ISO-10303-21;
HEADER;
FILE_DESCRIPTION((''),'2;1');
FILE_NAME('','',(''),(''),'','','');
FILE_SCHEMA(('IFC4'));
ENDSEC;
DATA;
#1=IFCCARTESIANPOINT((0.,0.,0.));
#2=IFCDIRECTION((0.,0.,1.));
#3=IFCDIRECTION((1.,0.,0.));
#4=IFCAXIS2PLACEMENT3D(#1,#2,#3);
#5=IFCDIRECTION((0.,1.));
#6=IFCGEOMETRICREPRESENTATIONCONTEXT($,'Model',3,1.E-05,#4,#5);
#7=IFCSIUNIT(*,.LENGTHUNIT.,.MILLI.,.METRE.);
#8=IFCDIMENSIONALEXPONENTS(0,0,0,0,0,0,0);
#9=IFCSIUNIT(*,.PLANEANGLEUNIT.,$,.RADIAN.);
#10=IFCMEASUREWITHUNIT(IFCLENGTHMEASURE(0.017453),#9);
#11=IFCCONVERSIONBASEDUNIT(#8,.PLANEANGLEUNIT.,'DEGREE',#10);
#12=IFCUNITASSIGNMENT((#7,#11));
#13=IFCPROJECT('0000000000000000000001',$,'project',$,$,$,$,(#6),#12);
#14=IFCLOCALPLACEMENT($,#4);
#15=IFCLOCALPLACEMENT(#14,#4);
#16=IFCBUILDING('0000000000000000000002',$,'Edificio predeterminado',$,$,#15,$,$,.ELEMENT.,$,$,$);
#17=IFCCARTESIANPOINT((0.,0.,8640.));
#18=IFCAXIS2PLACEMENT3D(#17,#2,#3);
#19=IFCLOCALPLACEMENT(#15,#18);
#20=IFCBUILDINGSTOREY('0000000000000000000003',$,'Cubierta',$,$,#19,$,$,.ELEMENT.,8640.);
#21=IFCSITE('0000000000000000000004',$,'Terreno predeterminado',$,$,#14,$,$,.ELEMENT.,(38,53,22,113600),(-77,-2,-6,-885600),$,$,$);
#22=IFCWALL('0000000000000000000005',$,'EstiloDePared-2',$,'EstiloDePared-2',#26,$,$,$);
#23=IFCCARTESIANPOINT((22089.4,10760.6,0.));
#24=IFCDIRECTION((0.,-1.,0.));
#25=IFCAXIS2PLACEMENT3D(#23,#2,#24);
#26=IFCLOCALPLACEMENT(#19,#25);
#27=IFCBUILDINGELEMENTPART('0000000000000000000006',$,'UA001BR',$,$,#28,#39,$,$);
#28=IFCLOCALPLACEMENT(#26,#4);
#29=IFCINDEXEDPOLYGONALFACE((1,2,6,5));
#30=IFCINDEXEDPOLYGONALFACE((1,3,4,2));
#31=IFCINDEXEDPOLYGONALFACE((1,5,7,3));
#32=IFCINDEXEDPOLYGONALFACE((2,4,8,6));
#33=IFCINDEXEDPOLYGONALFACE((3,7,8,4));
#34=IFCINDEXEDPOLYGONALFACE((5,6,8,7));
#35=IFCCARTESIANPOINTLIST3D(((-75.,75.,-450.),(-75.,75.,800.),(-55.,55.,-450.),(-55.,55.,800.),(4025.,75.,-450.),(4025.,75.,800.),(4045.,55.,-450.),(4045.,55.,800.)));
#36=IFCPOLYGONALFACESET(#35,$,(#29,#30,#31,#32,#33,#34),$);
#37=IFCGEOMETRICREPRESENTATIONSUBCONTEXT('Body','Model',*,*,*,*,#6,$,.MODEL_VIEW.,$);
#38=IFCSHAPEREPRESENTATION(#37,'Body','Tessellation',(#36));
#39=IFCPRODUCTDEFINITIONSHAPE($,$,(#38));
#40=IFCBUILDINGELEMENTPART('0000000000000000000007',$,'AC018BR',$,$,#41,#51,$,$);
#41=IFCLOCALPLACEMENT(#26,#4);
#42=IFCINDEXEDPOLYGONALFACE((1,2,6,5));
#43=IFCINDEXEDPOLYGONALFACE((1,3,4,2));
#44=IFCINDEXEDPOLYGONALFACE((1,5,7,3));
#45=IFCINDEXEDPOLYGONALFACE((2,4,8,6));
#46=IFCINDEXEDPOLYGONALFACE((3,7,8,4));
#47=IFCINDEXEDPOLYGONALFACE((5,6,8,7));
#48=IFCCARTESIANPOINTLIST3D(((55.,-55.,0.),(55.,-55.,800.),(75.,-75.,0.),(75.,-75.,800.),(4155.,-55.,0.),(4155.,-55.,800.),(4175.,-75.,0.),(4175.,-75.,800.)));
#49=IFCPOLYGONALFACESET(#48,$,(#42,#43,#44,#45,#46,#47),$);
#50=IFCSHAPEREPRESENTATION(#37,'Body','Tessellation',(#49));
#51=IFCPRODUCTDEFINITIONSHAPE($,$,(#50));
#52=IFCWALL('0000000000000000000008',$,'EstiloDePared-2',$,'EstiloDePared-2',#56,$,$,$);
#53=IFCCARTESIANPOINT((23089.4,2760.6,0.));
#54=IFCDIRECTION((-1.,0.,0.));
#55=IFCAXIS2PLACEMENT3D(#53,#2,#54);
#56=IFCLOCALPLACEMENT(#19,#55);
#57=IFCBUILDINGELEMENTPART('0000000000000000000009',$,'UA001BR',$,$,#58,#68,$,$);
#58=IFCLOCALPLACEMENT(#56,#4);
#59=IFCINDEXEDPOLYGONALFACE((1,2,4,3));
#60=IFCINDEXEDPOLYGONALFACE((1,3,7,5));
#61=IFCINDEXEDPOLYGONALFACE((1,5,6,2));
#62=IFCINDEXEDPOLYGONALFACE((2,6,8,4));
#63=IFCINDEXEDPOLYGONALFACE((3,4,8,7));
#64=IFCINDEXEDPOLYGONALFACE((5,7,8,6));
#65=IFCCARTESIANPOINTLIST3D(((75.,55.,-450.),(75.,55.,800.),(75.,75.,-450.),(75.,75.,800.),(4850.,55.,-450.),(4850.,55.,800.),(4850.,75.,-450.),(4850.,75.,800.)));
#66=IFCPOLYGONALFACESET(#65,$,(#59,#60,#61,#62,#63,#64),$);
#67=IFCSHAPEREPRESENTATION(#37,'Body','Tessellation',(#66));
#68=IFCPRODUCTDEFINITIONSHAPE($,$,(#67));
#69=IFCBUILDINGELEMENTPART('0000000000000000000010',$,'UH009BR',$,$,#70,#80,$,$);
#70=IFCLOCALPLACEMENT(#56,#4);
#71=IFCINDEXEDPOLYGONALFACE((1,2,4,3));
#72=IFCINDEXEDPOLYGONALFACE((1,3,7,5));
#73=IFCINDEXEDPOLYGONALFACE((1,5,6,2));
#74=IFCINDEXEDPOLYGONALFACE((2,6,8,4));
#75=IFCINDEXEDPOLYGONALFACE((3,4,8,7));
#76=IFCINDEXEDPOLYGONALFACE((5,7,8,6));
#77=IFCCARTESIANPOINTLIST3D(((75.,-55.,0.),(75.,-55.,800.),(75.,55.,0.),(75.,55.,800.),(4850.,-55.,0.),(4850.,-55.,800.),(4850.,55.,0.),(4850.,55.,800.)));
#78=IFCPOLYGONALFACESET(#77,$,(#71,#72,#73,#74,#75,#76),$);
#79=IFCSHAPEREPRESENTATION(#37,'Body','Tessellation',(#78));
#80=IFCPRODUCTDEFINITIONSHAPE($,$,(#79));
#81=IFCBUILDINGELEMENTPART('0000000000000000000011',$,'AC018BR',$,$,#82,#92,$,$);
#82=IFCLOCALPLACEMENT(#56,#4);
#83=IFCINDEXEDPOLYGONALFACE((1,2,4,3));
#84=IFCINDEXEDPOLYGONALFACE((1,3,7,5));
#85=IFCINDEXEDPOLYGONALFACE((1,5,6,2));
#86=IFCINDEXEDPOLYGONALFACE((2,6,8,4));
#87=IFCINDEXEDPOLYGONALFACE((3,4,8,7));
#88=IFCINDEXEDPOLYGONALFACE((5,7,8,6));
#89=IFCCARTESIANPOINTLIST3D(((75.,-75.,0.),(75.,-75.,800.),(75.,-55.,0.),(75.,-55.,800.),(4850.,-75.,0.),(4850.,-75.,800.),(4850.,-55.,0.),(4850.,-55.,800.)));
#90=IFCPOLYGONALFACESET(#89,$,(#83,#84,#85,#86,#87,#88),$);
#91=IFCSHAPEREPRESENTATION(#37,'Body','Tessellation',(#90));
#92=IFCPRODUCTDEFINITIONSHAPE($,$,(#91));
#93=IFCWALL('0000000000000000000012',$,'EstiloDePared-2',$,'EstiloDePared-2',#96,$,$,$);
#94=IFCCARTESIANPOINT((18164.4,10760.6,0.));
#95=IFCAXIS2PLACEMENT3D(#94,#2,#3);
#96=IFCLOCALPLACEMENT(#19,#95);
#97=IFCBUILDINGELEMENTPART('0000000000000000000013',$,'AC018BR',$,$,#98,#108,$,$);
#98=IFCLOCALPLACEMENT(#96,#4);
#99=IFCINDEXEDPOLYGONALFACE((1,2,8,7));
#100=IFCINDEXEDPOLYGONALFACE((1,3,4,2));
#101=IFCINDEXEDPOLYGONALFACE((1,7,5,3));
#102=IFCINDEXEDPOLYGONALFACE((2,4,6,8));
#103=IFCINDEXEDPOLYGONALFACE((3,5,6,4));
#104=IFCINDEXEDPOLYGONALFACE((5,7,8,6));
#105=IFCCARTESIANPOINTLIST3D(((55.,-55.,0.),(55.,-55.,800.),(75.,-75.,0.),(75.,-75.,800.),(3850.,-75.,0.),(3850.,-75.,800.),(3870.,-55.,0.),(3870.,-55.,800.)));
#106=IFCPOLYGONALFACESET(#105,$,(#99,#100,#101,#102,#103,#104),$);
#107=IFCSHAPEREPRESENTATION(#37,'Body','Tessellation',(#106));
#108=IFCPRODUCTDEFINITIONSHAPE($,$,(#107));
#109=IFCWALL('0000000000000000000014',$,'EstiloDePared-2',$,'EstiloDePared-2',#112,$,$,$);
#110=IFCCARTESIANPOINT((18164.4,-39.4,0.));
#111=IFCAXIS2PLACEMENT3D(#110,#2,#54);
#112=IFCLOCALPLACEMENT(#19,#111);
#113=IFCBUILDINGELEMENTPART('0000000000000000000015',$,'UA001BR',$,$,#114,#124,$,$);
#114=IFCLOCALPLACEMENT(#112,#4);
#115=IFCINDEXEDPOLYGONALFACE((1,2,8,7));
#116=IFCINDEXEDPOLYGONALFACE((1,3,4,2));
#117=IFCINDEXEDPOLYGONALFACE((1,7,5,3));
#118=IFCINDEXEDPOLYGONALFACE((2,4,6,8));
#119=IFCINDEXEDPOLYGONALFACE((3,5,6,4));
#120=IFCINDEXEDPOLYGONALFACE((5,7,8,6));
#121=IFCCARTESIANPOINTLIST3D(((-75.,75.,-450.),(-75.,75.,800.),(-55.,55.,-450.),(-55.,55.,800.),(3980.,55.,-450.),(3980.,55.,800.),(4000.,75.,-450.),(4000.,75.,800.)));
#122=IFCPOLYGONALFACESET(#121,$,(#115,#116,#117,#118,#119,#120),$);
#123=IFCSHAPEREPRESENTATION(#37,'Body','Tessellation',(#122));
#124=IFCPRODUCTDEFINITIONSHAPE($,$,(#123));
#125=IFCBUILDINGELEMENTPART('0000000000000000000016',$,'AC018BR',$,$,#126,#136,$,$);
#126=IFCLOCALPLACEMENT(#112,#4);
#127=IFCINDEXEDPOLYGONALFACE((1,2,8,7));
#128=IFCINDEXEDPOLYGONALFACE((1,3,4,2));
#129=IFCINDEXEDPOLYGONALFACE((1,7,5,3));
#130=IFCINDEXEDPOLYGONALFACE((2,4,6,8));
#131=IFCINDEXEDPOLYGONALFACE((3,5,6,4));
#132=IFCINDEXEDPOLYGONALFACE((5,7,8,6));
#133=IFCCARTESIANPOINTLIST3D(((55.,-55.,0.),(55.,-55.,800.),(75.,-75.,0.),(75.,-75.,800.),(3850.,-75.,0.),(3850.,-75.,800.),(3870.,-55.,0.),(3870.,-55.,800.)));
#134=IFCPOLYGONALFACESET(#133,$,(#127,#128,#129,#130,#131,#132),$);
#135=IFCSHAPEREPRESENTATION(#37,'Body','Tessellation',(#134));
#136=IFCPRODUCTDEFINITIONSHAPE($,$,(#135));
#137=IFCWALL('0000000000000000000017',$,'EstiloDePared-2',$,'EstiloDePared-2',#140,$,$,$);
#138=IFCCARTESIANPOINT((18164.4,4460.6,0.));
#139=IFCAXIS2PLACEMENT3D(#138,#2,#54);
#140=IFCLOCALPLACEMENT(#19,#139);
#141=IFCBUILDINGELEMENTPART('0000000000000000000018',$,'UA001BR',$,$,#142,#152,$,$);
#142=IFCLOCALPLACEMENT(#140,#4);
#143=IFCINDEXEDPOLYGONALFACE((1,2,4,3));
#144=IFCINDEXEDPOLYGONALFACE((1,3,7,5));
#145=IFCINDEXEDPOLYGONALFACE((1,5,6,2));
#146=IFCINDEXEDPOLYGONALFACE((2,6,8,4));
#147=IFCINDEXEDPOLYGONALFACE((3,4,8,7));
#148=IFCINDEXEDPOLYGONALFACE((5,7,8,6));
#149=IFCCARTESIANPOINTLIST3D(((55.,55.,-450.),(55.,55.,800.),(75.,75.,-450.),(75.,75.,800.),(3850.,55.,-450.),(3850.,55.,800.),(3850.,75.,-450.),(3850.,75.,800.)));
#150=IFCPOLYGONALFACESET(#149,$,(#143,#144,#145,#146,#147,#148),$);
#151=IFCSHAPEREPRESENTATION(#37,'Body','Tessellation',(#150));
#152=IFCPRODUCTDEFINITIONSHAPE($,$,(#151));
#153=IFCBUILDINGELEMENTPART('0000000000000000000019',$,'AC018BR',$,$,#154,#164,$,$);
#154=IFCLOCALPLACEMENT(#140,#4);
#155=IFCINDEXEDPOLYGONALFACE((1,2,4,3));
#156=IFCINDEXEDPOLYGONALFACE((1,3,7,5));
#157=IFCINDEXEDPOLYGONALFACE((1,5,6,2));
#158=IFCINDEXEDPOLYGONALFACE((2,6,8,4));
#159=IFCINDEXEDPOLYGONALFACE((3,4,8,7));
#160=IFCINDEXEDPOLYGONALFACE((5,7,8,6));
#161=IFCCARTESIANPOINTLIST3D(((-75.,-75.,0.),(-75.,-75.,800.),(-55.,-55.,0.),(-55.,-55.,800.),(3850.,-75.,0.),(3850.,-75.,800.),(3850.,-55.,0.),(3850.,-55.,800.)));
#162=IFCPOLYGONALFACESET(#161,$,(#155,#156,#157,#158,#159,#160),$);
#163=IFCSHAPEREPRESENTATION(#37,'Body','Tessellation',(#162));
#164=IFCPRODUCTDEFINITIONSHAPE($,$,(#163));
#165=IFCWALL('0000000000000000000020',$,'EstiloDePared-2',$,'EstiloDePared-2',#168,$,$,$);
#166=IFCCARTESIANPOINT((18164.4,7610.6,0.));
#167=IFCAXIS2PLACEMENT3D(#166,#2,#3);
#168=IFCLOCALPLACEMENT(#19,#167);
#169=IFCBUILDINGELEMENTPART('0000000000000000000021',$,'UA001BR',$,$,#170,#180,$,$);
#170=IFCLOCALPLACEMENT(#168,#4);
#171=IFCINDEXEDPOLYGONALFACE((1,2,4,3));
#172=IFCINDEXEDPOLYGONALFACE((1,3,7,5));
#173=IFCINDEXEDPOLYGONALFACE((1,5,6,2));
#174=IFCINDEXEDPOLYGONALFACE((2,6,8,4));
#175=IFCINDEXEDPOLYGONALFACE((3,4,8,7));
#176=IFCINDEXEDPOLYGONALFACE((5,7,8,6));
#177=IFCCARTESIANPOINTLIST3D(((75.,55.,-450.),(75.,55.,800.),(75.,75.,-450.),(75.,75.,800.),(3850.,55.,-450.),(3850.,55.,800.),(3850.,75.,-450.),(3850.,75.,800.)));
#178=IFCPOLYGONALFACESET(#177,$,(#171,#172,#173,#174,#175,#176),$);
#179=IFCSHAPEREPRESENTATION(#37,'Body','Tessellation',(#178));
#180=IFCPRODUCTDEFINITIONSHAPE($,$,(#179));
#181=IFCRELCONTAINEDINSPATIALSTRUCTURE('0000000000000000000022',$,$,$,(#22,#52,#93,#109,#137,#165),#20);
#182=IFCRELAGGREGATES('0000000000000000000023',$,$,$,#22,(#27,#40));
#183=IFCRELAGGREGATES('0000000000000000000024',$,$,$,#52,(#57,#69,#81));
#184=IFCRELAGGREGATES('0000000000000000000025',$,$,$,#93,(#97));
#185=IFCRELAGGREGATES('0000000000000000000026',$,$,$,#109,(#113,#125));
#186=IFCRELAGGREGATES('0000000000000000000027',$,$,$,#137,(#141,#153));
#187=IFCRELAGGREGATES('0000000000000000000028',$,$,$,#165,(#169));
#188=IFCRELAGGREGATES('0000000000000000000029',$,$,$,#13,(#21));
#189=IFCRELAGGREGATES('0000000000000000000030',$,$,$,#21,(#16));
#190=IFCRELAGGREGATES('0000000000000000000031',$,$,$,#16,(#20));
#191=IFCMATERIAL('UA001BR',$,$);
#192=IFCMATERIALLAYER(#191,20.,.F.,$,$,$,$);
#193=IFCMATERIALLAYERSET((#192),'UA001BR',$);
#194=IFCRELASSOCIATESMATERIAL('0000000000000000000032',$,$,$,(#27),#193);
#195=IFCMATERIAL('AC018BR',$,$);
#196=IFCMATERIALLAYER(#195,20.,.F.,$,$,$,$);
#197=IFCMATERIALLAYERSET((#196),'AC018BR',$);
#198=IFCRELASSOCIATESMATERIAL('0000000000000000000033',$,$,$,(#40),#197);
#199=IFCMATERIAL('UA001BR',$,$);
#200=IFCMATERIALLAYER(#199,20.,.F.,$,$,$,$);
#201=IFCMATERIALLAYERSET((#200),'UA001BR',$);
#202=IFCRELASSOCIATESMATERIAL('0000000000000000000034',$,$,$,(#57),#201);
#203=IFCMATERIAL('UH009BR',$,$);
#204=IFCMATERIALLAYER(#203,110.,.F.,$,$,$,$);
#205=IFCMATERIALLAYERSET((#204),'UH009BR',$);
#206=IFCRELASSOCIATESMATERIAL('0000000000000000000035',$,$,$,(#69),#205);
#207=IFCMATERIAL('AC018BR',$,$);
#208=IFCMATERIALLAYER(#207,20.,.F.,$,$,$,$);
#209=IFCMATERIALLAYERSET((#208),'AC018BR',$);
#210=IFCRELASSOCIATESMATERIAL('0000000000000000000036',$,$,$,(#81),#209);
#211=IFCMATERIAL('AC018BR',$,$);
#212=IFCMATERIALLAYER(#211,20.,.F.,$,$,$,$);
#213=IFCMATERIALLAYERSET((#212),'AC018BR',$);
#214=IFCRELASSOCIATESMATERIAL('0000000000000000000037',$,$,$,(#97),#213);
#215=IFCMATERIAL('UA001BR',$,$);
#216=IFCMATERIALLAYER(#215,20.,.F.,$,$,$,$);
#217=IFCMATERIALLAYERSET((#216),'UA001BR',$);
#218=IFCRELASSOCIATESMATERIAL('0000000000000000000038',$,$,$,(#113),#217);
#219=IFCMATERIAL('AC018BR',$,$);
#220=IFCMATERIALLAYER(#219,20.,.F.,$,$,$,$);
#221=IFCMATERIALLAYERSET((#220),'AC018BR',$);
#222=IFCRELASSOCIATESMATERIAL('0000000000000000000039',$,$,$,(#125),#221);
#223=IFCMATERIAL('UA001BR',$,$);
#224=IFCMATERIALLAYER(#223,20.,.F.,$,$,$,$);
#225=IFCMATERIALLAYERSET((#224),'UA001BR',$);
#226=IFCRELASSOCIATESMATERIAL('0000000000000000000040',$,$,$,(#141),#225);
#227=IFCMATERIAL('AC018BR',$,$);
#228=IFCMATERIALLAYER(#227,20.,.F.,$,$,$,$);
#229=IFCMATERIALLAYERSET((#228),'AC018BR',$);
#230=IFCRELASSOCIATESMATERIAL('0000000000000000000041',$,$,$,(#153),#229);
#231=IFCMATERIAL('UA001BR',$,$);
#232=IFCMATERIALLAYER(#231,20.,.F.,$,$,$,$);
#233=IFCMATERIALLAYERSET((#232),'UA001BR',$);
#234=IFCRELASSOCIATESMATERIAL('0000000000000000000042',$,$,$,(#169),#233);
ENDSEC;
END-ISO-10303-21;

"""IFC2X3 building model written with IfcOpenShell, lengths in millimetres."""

from ifc_helpers import new_model, entity, si_unit, converted_unit, direction, frame, origin_with_axes, place, context, subcontext, project, spatial, polyline, outline, extrude, material, layer, layer_set, layer_usage, element, aggregate, save


model = new_model("IFC2X3")

# Units and contexts
model_context = context("Model", 3, precision=1e-05, world=origin_with_axes(), true_north=direction((0.0, 1.0)))
body_context = subcontext(model_context, "Body", "Model", "MODEL_VIEW")
ifc_project = project(units=[si_unit("LENGTHUNIT", "METRE", prefix="MILLI"), converted_unit("PLANEANGLEUNIT", "DEGREE", entity("IfcLengthMeasure", 0.017453), si_unit("PLANEANGLEUNIT", "RADIAN"), dimensions=[0, 0, 0, 0, 0, 0, 0])], contexts=[model_context])

# Site, building, storey
site_placement = place(None, origin_with_axes())
site = spatial("IfcSite", under=ifc_project, at=site_placement, Name="Terreno predeterminado", CompositionType="ELEMENT", RefLatitude=(38, 53, 22, 113600), RefLongitude=(-77, -2, -6, -885600))
building_placement = place(site_placement, origin_with_axes())
building = spatial("IfcBuilding", under=site, at=building_placement, Name="Edificio predeterminado", CompositionType="ELEMENT")
storey_placement = place(building_placement, frame((0.0, 0.0, 8640.0), z_axis=(0.0, 0.0, 1.0), x_axis=(1.0, 0.0, 0.0)))
storey = spatial("IfcBuildingStorey", under=building, at=storey_placement, Name="Cubierta", CompositionType="ELEMENT", Elevation=8640.0)

# Walls, building element parts
wall_1_placement = place(storey_placement, frame((22089.4, 10760.6, 0.0), z_axis=(0.0, 0.0, 1.0), x_axis=(0.0, -1.0, 0.0)))
wall_1 = element("IfcWall", 1, at=wall_1_placement, inside=storey, Name="EstiloDePared-2", ObjectType="EstiloDePared-2")
ifc_material_1 = material(Name="UA001BR")
ifc_layer_1 = layer(ifc_material_1, 20.0, ventilated=False)
ifc_layer_set_1 = layer_set([ifc_layer_1], Name="UA001BR")
ifc_layer_usage_1 = layer_usage(ifc_layer_set_1, "AXIS2", "NEGATIVE", -75.0)
building_element_part_1_placement = place(wall_1_placement, origin_with_axes())
building_element_part_1 = element("IfcBuildingElementPart", 2, at=building_element_part_1_placement, material=ifc_layer_usage_1, Name="UA001BR", context=body_context, shape_type="SweptSolid", body=[
    extrude(outline(polyline([(4025.0, 75.0), (4045.0, 55.0), (-55.0, 55.0), (-75.0, 75.0), (4025.0, 75.0)])), frame((0.0, 0.0, -450.0), z_axis=(0.0, 0.0, 1.0), x_axis=(1.0, 0.0, 0.0)), (0.0, 0.0, 1.0), 1250.0),
])
ifc_material_2 = material(Name="AC018BR")
ifc_layer_2 = layer(ifc_material_2, 20.0, ventilated=False)
ifc_layer_set_2 = layer_set([ifc_layer_2], Name="AC018BR")
ifc_layer_usage_2 = layer_usage(ifc_layer_set_2, "AXIS2", "NEGATIVE", 55.0)
building_element_part_2_placement = place(wall_1_placement, origin_with_axes())
building_element_part_2 = element("IfcBuildingElementPart", 3, at=building_element_part_2_placement, material=ifc_layer_usage_2, Name="AC018BR", context=body_context, shape_type="SweptSolid", body=[
    extrude(outline(polyline([(4155.0, -55.0), (4175.0, -75.0), (75.0, -75.0), (55.0, -55.0), (4155.0, -55.0)])), origin_with_axes(), (0.0, 0.0, 1.0), 800.0),
])
aggregate(wall_1, [building_element_part_1, building_element_part_2])
wall_2_placement = place(storey_placement, frame((23089.4, 2760.6, 0.0), z_axis=(0.0, 0.0, 1.0), x_axis=(-1.0, 0.0, 0.0)))
wall_2 = element("IfcWall", 4, at=wall_2_placement, inside=storey, Name="EstiloDePared-2", ObjectType="EstiloDePared-2")
ifc_material_3 = material(Name="UA001BR")
ifc_layer_3 = layer(ifc_material_3, 20.0, ventilated=False)
ifc_layer_set_3 = layer_set([ifc_layer_3], Name="UA001BR")
ifc_layer_usage_3 = layer_usage(ifc_layer_set_3, "AXIS2", "NEGATIVE", -75.0)
building_element_part_3_placement = place(wall_2_placement, origin_with_axes())
building_element_part_3 = element("IfcBuildingElementPart", 5, at=building_element_part_3_placement, material=ifc_layer_usage_3, Name="UA001BR", context=body_context, shape_type="SweptSolid", body=[
    extrude(outline(polyline([(4850.0, 75.0), (4850.0, 55.0), (75.0, 55.0), (75.0, 75.0), (4850.0, 75.0)])), frame((0.0, 0.0, -450.0), z_axis=(0.0, 0.0, 1.0), x_axis=(1.0, 0.0, 0.0)), (0.0, 0.0, 1.0), 1250.0),
])
ifc_material_4 = material(Name="UH009BR")
ifc_layer_4 = layer(ifc_material_4, 110.0, ventilated=False)
ifc_layer_set_4 = layer_set([ifc_layer_4], Name="UH009BR")
ifc_layer_usage_4 = layer_usage(ifc_layer_set_4, "AXIS2", "NEGATIVE", -55.0)
building_element_part_4_placement = place(wall_2_placement, origin_with_axes())
building_element_part_4 = element("IfcBuildingElementPart", 6, at=building_element_part_4_placement, material=ifc_layer_usage_4, Name="UH009BR", context=body_context, shape_type="SweptSolid", body=[
    extrude(outline(polyline([(4850.0, 55.0), (4850.0, -55.0), (75.0, -55.0), (75.0, 55.0), (4850.0, 55.0)])), origin_with_axes(), (0.0, 0.0, 1.0), 800.0),
])
ifc_material_5 = material(Name="AC018BR")
ifc_layer_5 = layer(ifc_material_5, 20.0, ventilated=False)
ifc_layer_set_5 = layer_set([ifc_layer_5], Name="AC018BR")
ifc_layer_usage_5 = layer_usage(ifc_layer_set_5, "AXIS2", "NEGATIVE", 55.0)
building_element_part_5_placement = place(wall_2_placement, origin_with_axes())
building_element_part_5 = element("IfcBuildingElementPart", 7, at=building_element_part_5_placement, material=ifc_layer_usage_5, Name="AC018BR", context=body_context, shape_type="SweptSolid", body=[
    extrude(outline(polyline([(4850.0, -55.0), (4850.0, -75.0), (75.0, -75.0), (75.0, -55.0), (4850.0, -55.0)])), origin_with_axes(), (0.0, 0.0, 1.0), 800.0),
])
aggregate(wall_2, [building_element_part_3, building_element_part_4, building_element_part_5])

# Wall, building element part
wall_3_placement = place(storey_placement, frame((18164.4, 10760.6, 0.0), z_axis=(0.0, 0.0, 1.0), x_axis=(1.0, 0.0, 0.0)))
wall_3 = element("IfcWall", 8, at=wall_3_placement, inside=storey, Name="EstiloDePared-2", ObjectType="EstiloDePared-2")
ifc_material_6 = material(Name="AC018BR")
ifc_layer_6 = layer(ifc_material_6, 20.0, ventilated=False)
ifc_layer_set_6 = layer_set([ifc_layer_6], Name="AC018BR")
ifc_layer_usage_6 = layer_usage(ifc_layer_set_6, "AXIS2", "NEGATIVE", 55.0)
building_element_part_6_placement = place(wall_3_placement, origin_with_axes())
building_element_part_6 = element("IfcBuildingElementPart", 9, at=building_element_part_6_placement, material=ifc_layer_usage_6, Name="AC018BR", context=body_context, shape_type="SweptSolid", body=[
    extrude(outline(polyline([(3870.0, -55.0), (3850.0, -75.0), (75.0, -75.0), (55.0, -55.0), (3870.0, -55.0)])), origin_with_axes(), (0.0, 0.0, 1.0), 800.0),
])
aggregate(wall_3, [building_element_part_6])

# Walls, building element parts
wall_4_placement = place(storey_placement, frame((18164.4, -39.4, 0.0), z_axis=(0.0, 0.0, 1.0), x_axis=(-1.0, 0.0, 0.0)))
wall_4 = element("IfcWall", 10, at=wall_4_placement, inside=storey, Name="EstiloDePared-2", ObjectType="EstiloDePared-2")
ifc_material_7 = material(Name="UA001BR")
ifc_layer_7 = layer(ifc_material_7, 20.0, ventilated=False)
ifc_layer_set_7 = layer_set([ifc_layer_7], Name="UA001BR")
ifc_layer_usage_7 = layer_usage(ifc_layer_set_7, "AXIS2", "NEGATIVE", -75.0)
building_element_part_7_placement = place(wall_4_placement, origin_with_axes())
building_element_part_7 = element("IfcBuildingElementPart", 11, at=building_element_part_7_placement, material=ifc_layer_usage_7, Name="UA001BR", context=body_context, shape_type="SweptSolid", body=[
    extrude(outline(polyline([(4000.0, 75.0), (3980.0, 55.0), (-55.0, 55.0), (-75.0, 75.0), (4000.0, 75.0)])), frame((0.0, 0.0, -450.0), z_axis=(0.0, 0.0, 1.0), x_axis=(1.0, 0.0, 0.0)), (0.0, 0.0, 1.0), 1250.0),
])
ifc_material_8 = material(Name="AC018BR")
ifc_layer_8 = layer(ifc_material_8, 20.0, ventilated=False)
ifc_layer_set_8 = layer_set([ifc_layer_8], Name="AC018BR")
ifc_layer_usage_8 = layer_usage(ifc_layer_set_8, "AXIS2", "NEGATIVE", 55.0)
building_element_part_8_placement = place(wall_4_placement, origin_with_axes())
building_element_part_8 = element("IfcBuildingElementPart", 12, at=building_element_part_8_placement, material=ifc_layer_usage_8, Name="AC018BR", context=body_context, shape_type="SweptSolid", body=[
    extrude(outline(polyline([(3870.0, -55.0), (3850.0, -75.0), (75.0, -75.0), (55.0, -55.0), (3870.0, -55.0)])), origin_with_axes(), (0.0, 0.0, 1.0), 800.0),
])
aggregate(wall_4, [building_element_part_7, building_element_part_8])
wall_5_placement = place(storey_placement, frame((18164.4, 4460.6, 0.0), z_axis=(0.0, 0.0, 1.0), x_axis=(-1.0, 0.0, 0.0)))
wall_5 = element("IfcWall", 13, at=wall_5_placement, inside=storey, Name="EstiloDePared-2", ObjectType="EstiloDePared-2")
ifc_material_9 = material(Name="UA001BR")
ifc_layer_9 = layer(ifc_material_9, 20.0, ventilated=False)
ifc_layer_set_9 = layer_set([ifc_layer_9], Name="UA001BR")
ifc_layer_usage_9 = layer_usage(ifc_layer_set_9, "AXIS2", "NEGATIVE", -75.0)
building_element_part_9_placement = place(wall_5_placement, origin_with_axes())
building_element_part_9 = element("IfcBuildingElementPart", 14, at=building_element_part_9_placement, material=ifc_layer_usage_9, Name="UA001BR", context=body_context, shape_type="SweptSolid", body=[
    extrude(outline(polyline([(3850.0, 75.0), (3850.0, 55.0), (55.0, 55.0), (75.0, 75.0), (3850.0, 75.0)])), frame((0.0, 0.0, -450.0), z_axis=(0.0, 0.0, 1.0), x_axis=(1.0, 0.0, 0.0)), (0.0, 0.0, 1.0), 1250.0),
])
ifc_material_10 = material(Name="AC018BR")
ifc_layer_10 = layer(ifc_material_10, 20.0, ventilated=False)
ifc_layer_set_10 = layer_set([ifc_layer_10], Name="AC018BR")
ifc_layer_usage_10 = layer_usage(ifc_layer_set_10, "AXIS2", "NEGATIVE", 55.0)
building_element_part_10_placement = place(wall_5_placement, origin_with_axes())
building_element_part_10 = element("IfcBuildingElementPart", 15, at=building_element_part_10_placement, material=ifc_layer_usage_10, Name="AC018BR", context=body_context, shape_type="SweptSolid", body=[
    extrude(outline(polyline([(3850.0, -55.0), (3850.0, -75.0), (-75.0, -75.0), (-55.0, -55.0), (3850.0, -55.0)])), origin_with_axes(), (0.0, 0.0, 1.0), 800.0),
])
aggregate(wall_5, [building_element_part_9, building_element_part_10])
wall_6_placement = place(storey_placement, frame((18164.4, 7610.6, 0.0), z_axis=(0.0, 0.0, 1.0), x_axis=(1.0, 0.0, 0.0)))
wall_6 = element("IfcWall", 16, at=wall_6_placement, inside=storey, Name="EstiloDePared-2", ObjectType="EstiloDePared-2")
ifc_material_11 = material(Name="UA001BR")
ifc_layer_11 = layer(ifc_material_11, 20.0, ventilated=False)
ifc_layer_set_11 = layer_set([ifc_layer_11], Name="UA001BR")
ifc_layer_usage_11 = layer_usage(ifc_layer_set_11, "AXIS2", "NEGATIVE", -75.0)
building_element_part_11_placement = place(wall_6_placement, origin_with_axes())
building_element_part_11 = element("IfcBuildingElementPart", 17, at=building_element_part_11_placement, material=ifc_layer_usage_11, Name="UA001BR", context=body_context, shape_type="SweptSolid", body=[
    extrude(outline(polyline([(3850.0, 75.0), (3850.0, 55.0), (75.0, 55.0), (75.0, 75.0), (3850.0, 75.0)])), frame((0.0, 0.0, -450.0), z_axis=(0.0, 0.0, 1.0), x_axis=(1.0, 0.0, 0.0)), (0.0, 0.0, 1.0), 1250.0),
])
aggregate(wall_6, [building_element_part_11])

save(model, "model.ifc")
